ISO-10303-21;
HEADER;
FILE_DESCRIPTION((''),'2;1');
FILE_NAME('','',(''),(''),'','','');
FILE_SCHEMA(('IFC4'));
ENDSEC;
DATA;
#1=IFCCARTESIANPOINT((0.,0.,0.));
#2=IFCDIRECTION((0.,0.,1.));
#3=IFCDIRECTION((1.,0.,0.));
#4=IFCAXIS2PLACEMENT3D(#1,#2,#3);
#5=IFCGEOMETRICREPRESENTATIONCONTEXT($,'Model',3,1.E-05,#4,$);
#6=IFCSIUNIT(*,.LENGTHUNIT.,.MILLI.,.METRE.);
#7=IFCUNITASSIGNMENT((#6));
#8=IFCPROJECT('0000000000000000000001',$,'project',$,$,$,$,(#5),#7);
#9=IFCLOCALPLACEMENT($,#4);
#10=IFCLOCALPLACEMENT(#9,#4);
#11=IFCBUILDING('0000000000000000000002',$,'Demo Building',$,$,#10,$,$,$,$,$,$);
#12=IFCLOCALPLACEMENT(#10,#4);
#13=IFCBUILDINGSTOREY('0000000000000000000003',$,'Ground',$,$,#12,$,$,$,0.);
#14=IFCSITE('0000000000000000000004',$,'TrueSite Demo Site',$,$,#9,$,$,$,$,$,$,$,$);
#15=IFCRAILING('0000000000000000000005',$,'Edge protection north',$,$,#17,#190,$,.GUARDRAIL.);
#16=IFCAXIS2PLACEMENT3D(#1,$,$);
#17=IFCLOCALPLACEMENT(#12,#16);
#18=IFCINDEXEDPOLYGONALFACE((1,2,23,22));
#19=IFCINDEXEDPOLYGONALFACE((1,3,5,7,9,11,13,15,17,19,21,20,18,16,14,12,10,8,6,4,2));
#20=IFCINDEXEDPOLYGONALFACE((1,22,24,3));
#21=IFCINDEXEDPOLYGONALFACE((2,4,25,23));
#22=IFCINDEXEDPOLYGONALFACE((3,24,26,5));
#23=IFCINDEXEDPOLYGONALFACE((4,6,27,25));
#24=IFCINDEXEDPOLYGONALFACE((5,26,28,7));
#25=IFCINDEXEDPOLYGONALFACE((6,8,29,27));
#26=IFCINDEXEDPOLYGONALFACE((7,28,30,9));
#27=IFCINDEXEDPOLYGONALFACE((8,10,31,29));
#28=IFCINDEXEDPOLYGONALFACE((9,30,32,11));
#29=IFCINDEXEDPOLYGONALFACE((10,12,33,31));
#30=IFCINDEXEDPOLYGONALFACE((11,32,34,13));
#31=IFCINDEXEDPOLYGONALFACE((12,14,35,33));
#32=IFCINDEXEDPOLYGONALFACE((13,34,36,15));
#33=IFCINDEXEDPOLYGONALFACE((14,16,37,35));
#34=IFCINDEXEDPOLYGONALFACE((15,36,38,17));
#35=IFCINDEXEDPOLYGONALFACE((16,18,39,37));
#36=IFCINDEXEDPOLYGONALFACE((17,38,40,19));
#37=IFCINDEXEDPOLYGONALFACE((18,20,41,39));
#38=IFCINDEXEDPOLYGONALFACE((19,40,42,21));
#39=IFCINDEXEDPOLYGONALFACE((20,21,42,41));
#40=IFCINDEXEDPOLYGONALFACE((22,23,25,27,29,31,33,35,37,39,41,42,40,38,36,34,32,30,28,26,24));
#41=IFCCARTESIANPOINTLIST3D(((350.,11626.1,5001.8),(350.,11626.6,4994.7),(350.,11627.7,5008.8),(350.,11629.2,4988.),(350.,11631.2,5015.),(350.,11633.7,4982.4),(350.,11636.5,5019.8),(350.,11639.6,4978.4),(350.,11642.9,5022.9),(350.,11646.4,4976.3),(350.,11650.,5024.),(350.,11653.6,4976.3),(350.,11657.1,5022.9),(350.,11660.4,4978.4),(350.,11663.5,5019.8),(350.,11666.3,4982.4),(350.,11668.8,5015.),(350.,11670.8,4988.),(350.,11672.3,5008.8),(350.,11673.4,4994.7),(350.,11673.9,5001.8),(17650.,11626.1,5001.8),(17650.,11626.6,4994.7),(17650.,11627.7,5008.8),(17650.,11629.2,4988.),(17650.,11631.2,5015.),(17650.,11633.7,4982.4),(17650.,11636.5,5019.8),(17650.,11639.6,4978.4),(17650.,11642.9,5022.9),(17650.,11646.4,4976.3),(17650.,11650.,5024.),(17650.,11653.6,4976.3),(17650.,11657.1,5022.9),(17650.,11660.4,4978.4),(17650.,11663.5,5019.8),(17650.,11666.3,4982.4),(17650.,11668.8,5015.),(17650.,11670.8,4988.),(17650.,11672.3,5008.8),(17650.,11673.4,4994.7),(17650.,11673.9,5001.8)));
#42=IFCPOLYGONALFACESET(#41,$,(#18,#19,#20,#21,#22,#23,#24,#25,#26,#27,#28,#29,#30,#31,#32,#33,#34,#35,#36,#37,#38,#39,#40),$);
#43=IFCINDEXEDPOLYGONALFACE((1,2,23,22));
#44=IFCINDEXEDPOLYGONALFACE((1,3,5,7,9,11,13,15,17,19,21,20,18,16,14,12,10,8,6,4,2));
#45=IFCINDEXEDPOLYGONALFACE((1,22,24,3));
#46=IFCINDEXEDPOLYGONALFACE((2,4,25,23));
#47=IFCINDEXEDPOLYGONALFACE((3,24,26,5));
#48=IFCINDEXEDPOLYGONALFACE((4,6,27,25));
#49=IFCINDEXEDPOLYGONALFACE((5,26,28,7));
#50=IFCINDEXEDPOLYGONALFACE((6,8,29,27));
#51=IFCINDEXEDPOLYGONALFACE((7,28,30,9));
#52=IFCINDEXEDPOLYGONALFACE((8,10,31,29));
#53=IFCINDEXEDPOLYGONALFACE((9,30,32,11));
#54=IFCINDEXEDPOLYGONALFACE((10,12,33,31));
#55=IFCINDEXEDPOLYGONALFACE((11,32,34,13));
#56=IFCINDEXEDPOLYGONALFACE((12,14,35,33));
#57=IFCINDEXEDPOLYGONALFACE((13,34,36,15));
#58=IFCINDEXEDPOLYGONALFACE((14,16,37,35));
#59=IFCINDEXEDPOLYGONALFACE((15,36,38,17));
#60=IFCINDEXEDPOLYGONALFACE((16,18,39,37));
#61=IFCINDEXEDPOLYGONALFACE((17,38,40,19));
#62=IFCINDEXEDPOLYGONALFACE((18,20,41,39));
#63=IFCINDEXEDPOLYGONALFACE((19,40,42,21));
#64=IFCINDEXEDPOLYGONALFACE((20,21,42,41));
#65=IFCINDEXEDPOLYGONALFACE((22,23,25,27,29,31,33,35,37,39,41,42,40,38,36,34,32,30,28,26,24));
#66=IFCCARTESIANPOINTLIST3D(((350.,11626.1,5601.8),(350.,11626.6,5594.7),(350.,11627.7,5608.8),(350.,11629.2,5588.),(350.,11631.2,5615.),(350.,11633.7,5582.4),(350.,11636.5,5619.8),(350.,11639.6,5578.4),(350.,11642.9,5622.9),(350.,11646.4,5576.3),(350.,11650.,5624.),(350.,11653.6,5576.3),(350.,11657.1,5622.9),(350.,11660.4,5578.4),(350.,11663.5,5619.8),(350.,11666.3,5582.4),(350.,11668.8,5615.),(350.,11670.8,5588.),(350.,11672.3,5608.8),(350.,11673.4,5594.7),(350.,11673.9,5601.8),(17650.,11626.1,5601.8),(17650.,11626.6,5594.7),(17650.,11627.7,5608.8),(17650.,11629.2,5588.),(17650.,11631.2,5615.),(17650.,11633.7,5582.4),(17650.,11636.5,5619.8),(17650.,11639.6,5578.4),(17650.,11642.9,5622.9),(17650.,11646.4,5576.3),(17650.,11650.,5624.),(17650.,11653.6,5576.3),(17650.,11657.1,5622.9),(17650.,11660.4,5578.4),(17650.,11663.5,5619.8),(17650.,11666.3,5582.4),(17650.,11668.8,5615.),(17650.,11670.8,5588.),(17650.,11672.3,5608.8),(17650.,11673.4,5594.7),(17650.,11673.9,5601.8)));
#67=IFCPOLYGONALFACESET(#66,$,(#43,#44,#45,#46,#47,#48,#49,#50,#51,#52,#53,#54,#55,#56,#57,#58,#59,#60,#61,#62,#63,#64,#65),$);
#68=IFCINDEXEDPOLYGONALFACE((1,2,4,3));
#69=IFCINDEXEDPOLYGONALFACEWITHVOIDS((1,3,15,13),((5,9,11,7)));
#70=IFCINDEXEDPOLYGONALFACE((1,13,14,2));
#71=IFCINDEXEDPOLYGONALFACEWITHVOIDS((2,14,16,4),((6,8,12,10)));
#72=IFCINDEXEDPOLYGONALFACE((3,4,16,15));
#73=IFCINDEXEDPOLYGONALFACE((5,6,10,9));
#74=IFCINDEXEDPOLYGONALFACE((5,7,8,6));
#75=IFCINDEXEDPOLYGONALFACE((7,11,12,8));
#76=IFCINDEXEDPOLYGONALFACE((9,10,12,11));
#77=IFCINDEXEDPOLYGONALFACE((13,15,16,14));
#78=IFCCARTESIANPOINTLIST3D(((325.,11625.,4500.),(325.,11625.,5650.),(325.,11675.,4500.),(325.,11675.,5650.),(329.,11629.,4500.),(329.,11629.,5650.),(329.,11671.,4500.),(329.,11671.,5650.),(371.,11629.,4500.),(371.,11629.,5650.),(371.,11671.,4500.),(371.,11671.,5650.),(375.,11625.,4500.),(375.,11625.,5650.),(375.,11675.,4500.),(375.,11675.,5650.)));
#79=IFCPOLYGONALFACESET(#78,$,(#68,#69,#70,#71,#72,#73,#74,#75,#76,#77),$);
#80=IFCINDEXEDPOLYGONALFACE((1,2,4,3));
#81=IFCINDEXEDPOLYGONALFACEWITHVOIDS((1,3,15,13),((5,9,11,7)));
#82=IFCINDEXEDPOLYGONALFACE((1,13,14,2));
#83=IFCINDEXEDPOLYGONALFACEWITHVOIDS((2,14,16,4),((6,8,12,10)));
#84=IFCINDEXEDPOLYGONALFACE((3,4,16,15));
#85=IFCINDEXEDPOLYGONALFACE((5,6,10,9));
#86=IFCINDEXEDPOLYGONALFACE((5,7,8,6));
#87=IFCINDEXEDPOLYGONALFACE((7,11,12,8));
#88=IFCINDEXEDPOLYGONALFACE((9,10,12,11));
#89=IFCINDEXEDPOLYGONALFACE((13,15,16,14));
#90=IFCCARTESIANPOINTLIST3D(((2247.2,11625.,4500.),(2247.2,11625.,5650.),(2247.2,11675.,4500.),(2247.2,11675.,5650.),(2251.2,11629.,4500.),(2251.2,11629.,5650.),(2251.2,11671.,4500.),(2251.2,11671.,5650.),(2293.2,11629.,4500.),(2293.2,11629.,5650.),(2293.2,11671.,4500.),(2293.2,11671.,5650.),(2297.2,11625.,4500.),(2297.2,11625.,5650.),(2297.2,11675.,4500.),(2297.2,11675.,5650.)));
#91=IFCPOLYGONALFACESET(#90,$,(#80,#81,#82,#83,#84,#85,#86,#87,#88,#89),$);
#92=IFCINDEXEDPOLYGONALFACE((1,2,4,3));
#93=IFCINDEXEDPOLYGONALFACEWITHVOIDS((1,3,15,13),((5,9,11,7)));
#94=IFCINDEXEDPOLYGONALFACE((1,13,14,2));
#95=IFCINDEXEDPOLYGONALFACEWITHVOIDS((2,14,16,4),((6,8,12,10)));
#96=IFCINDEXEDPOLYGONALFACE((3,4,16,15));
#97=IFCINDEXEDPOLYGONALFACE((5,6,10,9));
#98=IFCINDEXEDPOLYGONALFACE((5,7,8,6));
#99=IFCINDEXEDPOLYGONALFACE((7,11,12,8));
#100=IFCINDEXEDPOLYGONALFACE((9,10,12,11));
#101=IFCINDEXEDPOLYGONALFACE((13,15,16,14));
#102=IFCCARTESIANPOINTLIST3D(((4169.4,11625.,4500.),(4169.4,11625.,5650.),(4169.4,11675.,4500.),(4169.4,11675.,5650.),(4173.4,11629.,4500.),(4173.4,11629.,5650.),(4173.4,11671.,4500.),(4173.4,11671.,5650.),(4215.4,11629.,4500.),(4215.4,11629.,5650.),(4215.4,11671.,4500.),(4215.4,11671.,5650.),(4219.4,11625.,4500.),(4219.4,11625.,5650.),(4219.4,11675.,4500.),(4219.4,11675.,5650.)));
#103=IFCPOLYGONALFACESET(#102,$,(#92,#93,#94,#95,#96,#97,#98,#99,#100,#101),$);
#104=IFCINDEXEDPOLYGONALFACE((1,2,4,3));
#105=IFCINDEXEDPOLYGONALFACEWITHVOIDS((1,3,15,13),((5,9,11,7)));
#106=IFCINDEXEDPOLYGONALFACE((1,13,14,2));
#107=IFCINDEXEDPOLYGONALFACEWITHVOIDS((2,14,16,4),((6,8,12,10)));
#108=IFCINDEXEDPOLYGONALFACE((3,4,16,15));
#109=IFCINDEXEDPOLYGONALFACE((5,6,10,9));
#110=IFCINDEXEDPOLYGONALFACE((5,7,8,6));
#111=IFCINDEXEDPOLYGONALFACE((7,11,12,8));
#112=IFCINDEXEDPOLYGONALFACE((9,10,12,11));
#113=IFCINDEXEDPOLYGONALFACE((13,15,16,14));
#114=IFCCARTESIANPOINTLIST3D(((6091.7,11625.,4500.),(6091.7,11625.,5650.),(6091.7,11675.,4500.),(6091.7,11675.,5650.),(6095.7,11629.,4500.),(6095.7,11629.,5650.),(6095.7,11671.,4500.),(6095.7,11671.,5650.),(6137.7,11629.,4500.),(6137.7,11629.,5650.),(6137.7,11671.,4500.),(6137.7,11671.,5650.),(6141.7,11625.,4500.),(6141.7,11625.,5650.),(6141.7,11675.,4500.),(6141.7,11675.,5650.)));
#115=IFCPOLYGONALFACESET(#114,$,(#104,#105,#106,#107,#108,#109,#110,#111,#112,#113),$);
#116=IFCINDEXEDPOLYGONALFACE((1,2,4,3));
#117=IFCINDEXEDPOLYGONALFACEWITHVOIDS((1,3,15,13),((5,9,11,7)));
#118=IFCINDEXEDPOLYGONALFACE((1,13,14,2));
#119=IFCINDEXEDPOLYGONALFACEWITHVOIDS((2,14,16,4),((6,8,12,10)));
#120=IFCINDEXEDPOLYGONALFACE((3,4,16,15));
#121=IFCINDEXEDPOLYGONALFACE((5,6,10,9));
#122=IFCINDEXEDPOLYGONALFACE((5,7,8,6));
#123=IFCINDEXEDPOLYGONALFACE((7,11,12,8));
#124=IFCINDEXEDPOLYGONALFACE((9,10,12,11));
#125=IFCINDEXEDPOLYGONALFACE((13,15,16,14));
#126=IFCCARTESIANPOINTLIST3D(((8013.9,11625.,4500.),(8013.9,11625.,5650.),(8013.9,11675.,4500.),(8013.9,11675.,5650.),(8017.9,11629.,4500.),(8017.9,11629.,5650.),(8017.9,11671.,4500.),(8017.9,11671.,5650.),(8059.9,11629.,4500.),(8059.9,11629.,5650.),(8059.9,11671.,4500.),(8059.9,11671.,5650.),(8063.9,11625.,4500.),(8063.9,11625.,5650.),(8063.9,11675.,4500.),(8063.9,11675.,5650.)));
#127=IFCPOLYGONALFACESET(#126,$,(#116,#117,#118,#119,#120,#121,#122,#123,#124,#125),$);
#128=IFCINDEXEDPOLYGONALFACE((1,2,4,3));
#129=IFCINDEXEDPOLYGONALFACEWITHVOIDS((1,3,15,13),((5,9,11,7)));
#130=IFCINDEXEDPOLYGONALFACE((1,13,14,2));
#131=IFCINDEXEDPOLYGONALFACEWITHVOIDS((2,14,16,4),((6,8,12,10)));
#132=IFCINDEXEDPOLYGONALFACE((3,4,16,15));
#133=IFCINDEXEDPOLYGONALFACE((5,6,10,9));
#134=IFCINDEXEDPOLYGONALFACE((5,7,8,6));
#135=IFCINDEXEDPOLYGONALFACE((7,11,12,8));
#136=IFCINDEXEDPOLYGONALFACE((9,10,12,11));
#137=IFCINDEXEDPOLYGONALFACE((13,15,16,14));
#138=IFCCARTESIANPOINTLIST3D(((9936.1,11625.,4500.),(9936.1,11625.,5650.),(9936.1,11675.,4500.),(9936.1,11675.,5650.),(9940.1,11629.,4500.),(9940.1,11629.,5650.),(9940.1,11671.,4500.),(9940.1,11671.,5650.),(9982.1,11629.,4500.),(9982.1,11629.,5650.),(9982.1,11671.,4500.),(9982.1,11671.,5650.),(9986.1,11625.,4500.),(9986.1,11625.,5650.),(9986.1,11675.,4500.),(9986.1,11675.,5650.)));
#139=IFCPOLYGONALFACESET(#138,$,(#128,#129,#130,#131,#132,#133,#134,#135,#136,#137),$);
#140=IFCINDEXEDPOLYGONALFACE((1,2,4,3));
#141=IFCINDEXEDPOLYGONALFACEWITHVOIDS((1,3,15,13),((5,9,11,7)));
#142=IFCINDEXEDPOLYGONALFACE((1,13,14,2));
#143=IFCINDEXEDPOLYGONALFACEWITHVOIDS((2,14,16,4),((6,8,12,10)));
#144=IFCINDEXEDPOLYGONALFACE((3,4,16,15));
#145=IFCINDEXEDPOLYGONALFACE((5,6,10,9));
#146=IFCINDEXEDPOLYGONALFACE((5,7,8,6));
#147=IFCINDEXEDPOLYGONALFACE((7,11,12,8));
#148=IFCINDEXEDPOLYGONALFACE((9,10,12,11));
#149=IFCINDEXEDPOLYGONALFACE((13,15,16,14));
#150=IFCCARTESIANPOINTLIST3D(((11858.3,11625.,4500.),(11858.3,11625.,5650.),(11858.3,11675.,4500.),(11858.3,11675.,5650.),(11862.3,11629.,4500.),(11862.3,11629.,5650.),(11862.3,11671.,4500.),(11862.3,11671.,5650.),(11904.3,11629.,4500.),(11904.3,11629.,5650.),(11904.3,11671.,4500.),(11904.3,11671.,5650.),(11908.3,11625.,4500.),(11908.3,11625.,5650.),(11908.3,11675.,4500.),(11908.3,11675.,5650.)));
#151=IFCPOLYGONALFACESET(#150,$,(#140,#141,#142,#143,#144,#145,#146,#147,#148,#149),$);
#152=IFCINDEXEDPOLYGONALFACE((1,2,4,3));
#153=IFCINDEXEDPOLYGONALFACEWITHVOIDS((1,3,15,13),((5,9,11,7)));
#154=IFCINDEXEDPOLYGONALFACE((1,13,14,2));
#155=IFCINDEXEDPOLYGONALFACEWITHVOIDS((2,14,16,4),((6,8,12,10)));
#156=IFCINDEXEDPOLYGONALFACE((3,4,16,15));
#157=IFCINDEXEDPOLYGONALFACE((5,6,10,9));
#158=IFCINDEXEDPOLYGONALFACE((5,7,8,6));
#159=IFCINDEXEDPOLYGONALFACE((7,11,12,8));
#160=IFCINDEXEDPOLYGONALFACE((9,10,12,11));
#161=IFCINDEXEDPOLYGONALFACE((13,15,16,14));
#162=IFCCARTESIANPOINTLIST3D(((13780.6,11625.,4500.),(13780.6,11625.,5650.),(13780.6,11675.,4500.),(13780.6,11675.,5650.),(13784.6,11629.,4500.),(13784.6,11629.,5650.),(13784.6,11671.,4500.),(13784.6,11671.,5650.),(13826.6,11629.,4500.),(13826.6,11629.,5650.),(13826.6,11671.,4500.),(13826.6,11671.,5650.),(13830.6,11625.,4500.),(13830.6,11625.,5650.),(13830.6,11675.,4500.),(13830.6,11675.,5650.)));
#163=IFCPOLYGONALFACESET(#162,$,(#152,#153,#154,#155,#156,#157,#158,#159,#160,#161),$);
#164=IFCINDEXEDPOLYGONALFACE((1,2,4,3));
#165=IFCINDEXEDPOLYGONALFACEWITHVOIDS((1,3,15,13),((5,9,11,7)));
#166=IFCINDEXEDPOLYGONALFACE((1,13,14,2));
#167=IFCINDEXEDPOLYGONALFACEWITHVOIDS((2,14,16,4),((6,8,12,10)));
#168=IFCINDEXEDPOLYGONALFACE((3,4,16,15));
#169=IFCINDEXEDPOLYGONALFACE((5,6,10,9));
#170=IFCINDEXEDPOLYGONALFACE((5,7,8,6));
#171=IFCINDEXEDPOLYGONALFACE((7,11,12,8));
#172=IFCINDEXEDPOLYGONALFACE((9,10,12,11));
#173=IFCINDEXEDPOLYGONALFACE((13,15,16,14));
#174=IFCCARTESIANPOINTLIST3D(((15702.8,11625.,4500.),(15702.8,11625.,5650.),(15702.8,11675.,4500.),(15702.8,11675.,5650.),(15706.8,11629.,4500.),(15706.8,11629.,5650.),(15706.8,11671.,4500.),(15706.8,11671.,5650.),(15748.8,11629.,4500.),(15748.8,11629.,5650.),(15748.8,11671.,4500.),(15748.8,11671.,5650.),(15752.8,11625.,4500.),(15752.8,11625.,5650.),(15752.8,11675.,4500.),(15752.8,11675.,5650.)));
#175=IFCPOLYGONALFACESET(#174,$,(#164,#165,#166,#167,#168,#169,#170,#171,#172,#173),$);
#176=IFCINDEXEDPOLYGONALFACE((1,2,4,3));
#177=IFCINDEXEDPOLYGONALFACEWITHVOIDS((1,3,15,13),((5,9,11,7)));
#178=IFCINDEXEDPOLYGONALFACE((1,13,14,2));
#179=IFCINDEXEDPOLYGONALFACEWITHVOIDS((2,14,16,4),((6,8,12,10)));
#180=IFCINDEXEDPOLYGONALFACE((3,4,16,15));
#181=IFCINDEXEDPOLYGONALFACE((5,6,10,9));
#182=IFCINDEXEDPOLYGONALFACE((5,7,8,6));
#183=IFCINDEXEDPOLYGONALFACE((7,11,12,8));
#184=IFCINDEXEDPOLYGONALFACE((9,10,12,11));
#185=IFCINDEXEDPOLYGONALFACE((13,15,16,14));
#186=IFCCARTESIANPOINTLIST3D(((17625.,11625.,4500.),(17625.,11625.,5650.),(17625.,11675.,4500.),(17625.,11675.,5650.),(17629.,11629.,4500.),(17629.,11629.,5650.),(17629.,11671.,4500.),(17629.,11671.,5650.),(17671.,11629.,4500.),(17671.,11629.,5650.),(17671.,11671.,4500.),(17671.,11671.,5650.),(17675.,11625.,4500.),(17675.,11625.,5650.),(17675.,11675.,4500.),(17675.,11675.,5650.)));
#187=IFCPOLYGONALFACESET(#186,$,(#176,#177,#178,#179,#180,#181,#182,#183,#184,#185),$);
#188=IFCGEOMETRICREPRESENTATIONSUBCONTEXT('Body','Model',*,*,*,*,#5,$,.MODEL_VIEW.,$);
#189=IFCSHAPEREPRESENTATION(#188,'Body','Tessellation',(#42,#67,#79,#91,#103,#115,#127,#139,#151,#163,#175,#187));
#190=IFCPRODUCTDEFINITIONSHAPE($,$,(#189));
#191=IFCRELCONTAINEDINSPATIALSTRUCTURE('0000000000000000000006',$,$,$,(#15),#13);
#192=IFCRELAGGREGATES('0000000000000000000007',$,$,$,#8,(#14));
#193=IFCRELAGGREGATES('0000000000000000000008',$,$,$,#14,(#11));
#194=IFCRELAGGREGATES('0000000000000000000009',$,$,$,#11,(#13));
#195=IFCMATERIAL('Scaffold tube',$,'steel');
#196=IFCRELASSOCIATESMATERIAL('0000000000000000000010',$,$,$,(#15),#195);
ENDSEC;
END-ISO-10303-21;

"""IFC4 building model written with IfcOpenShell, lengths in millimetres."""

from ifc_helpers import new_model, si_unit, frame, origin_with_axes, place, context, subcontext, project, spatial, hollow_rectangle, circle, extrude, material, element, save


model = new_model("IFC4")

# Units and contexts
model_context = context("Model", 3, precision=1e-05, world=origin_with_axes())
body_context = subcontext(model_context, "Body", "Model", "MODEL_VIEW")
ifc_project = project(units=[si_unit("LENGTHUNIT", "METRE", prefix="MILLI")], contexts=[model_context])

# Site, building, storey
site_placement = place(None, origin_with_axes())
site = spatial("IfcSite", under=ifc_project, at=site_placement, Name="TrueSite Demo Site")
building_placement = place(site_placement, origin_with_axes())
building = spatial("IfcBuilding", under=site, at=building_placement, Name="Demo Building")
storey_placement = place(building_placement, origin_with_axes())
storey = spatial("IfcBuildingStorey", under=building, at=storey_placement, Name="Ground", Elevation=0.0)

# Railing
ifc_material_1 = material(Name="Scaffold tube", Category="steel")
railing_1_placement = place(storey_placement, origin_with_axes())
element("IfcRailing", 1, at=railing_1_placement, inside=storey, material=ifc_material_1, Name="Edge protection north", PredefinedType="GUARDRAIL", context=body_context, shape_type="SweptSolid", body=[
    extrude(circle(Radius=24.0), frame((350.0, 11650.0, 5000.0), z_axis=(1.0, 0.0, 0.0), x_axis=(0.0, 0.0, 1.0)), (0.0, 0.0, 1.0), 17300.0),
    extrude(circle(Radius=24.0), frame((350.0, 11650.0, 5600.0), z_axis=(1.0, 0.0, 0.0), x_axis=(0.0, 0.0, 1.0)), (0.0, 0.0, 1.0), 17300.0),
    extrude(hollow_rectangle(XDim=50.0, YDim=50.0, WallThickness=4.0), frame((350.0, 11650.0, 4500.0), z_axis=(0.0, 0.0, 1.0), x_axis=(1.0, 0.0, 0.0)), (0.0, 0.0, 1.0), 1150.0),
    extrude(hollow_rectangle(XDim=50.0, YDim=50.0, WallThickness=4.0), frame((2272.2, 11650.0, 4500.0), z_axis=(0.0, 0.0, 1.0), x_axis=(1.0, 0.0, 0.0)), (0.0, 0.0, 1.0), 1150.0),
    extrude(hollow_rectangle(XDim=50.0, YDim=50.0, WallThickness=4.0), frame((4194.4, 11650.0, 4500.0), z_axis=(0.0, 0.0, 1.0), x_axis=(1.0, 0.0, 0.0)), (0.0, 0.0, 1.0), 1150.0),
    extrude(hollow_rectangle(XDim=50.0, YDim=50.0, WallThickness=4.0), frame((6116.7, 11650.0, 4500.0), z_axis=(0.0, 0.0, 1.0), x_axis=(1.0, 0.0, 0.0)), (0.0, 0.0, 1.0), 1150.0),
    extrude(hollow_rectangle(XDim=50.0, YDim=50.0, WallThickness=4.0), frame((8038.9, 11650.0, 4500.0), z_axis=(0.0, 0.0, 1.0), x_axis=(1.0, 0.0, 0.0)), (0.0, 0.0, 1.0), 1150.0),
    extrude(hollow_rectangle(XDim=50.0, YDim=50.0, WallThickness=4.0), frame((9961.1, 11650.0, 4500.0), z_axis=(0.0, 0.0, 1.0), x_axis=(1.0, 0.0, 0.0)), (0.0, 0.0, 1.0), 1150.0),
    extrude(hollow_rectangle(XDim=50.0, YDim=50.0, WallThickness=4.0), frame((11883.3, 11650.0, 4500.0), z_axis=(0.0, 0.0, 1.0), x_axis=(1.0, 0.0, 0.0)), (0.0, 0.0, 1.0), 1150.0),
    extrude(hollow_rectangle(XDim=50.0, YDim=50.0, WallThickness=4.0), frame((13805.6, 11650.0, 4500.0), z_axis=(0.0, 0.0, 1.0), x_axis=(1.0, 0.0, 0.0)), (0.0, 0.0, 1.0), 1150.0),
    extrude(hollow_rectangle(XDim=50.0, YDim=50.0, WallThickness=4.0), frame((15727.8, 11650.0, 4500.0), z_axis=(0.0, 0.0, 1.0), x_axis=(1.0, 0.0, 0.0)), (0.0, 0.0, 1.0), 1150.0),
    extrude(hollow_rectangle(XDim=50.0, YDim=50.0, WallThickness=4.0), frame((17650.0, 11650.0, 4500.0), z_axis=(0.0, 0.0, 1.0), x_axis=(1.0, 0.0, 0.0)), (0.0, 0.0, 1.0), 1150.0),
])

save(model, "model.ifc")
